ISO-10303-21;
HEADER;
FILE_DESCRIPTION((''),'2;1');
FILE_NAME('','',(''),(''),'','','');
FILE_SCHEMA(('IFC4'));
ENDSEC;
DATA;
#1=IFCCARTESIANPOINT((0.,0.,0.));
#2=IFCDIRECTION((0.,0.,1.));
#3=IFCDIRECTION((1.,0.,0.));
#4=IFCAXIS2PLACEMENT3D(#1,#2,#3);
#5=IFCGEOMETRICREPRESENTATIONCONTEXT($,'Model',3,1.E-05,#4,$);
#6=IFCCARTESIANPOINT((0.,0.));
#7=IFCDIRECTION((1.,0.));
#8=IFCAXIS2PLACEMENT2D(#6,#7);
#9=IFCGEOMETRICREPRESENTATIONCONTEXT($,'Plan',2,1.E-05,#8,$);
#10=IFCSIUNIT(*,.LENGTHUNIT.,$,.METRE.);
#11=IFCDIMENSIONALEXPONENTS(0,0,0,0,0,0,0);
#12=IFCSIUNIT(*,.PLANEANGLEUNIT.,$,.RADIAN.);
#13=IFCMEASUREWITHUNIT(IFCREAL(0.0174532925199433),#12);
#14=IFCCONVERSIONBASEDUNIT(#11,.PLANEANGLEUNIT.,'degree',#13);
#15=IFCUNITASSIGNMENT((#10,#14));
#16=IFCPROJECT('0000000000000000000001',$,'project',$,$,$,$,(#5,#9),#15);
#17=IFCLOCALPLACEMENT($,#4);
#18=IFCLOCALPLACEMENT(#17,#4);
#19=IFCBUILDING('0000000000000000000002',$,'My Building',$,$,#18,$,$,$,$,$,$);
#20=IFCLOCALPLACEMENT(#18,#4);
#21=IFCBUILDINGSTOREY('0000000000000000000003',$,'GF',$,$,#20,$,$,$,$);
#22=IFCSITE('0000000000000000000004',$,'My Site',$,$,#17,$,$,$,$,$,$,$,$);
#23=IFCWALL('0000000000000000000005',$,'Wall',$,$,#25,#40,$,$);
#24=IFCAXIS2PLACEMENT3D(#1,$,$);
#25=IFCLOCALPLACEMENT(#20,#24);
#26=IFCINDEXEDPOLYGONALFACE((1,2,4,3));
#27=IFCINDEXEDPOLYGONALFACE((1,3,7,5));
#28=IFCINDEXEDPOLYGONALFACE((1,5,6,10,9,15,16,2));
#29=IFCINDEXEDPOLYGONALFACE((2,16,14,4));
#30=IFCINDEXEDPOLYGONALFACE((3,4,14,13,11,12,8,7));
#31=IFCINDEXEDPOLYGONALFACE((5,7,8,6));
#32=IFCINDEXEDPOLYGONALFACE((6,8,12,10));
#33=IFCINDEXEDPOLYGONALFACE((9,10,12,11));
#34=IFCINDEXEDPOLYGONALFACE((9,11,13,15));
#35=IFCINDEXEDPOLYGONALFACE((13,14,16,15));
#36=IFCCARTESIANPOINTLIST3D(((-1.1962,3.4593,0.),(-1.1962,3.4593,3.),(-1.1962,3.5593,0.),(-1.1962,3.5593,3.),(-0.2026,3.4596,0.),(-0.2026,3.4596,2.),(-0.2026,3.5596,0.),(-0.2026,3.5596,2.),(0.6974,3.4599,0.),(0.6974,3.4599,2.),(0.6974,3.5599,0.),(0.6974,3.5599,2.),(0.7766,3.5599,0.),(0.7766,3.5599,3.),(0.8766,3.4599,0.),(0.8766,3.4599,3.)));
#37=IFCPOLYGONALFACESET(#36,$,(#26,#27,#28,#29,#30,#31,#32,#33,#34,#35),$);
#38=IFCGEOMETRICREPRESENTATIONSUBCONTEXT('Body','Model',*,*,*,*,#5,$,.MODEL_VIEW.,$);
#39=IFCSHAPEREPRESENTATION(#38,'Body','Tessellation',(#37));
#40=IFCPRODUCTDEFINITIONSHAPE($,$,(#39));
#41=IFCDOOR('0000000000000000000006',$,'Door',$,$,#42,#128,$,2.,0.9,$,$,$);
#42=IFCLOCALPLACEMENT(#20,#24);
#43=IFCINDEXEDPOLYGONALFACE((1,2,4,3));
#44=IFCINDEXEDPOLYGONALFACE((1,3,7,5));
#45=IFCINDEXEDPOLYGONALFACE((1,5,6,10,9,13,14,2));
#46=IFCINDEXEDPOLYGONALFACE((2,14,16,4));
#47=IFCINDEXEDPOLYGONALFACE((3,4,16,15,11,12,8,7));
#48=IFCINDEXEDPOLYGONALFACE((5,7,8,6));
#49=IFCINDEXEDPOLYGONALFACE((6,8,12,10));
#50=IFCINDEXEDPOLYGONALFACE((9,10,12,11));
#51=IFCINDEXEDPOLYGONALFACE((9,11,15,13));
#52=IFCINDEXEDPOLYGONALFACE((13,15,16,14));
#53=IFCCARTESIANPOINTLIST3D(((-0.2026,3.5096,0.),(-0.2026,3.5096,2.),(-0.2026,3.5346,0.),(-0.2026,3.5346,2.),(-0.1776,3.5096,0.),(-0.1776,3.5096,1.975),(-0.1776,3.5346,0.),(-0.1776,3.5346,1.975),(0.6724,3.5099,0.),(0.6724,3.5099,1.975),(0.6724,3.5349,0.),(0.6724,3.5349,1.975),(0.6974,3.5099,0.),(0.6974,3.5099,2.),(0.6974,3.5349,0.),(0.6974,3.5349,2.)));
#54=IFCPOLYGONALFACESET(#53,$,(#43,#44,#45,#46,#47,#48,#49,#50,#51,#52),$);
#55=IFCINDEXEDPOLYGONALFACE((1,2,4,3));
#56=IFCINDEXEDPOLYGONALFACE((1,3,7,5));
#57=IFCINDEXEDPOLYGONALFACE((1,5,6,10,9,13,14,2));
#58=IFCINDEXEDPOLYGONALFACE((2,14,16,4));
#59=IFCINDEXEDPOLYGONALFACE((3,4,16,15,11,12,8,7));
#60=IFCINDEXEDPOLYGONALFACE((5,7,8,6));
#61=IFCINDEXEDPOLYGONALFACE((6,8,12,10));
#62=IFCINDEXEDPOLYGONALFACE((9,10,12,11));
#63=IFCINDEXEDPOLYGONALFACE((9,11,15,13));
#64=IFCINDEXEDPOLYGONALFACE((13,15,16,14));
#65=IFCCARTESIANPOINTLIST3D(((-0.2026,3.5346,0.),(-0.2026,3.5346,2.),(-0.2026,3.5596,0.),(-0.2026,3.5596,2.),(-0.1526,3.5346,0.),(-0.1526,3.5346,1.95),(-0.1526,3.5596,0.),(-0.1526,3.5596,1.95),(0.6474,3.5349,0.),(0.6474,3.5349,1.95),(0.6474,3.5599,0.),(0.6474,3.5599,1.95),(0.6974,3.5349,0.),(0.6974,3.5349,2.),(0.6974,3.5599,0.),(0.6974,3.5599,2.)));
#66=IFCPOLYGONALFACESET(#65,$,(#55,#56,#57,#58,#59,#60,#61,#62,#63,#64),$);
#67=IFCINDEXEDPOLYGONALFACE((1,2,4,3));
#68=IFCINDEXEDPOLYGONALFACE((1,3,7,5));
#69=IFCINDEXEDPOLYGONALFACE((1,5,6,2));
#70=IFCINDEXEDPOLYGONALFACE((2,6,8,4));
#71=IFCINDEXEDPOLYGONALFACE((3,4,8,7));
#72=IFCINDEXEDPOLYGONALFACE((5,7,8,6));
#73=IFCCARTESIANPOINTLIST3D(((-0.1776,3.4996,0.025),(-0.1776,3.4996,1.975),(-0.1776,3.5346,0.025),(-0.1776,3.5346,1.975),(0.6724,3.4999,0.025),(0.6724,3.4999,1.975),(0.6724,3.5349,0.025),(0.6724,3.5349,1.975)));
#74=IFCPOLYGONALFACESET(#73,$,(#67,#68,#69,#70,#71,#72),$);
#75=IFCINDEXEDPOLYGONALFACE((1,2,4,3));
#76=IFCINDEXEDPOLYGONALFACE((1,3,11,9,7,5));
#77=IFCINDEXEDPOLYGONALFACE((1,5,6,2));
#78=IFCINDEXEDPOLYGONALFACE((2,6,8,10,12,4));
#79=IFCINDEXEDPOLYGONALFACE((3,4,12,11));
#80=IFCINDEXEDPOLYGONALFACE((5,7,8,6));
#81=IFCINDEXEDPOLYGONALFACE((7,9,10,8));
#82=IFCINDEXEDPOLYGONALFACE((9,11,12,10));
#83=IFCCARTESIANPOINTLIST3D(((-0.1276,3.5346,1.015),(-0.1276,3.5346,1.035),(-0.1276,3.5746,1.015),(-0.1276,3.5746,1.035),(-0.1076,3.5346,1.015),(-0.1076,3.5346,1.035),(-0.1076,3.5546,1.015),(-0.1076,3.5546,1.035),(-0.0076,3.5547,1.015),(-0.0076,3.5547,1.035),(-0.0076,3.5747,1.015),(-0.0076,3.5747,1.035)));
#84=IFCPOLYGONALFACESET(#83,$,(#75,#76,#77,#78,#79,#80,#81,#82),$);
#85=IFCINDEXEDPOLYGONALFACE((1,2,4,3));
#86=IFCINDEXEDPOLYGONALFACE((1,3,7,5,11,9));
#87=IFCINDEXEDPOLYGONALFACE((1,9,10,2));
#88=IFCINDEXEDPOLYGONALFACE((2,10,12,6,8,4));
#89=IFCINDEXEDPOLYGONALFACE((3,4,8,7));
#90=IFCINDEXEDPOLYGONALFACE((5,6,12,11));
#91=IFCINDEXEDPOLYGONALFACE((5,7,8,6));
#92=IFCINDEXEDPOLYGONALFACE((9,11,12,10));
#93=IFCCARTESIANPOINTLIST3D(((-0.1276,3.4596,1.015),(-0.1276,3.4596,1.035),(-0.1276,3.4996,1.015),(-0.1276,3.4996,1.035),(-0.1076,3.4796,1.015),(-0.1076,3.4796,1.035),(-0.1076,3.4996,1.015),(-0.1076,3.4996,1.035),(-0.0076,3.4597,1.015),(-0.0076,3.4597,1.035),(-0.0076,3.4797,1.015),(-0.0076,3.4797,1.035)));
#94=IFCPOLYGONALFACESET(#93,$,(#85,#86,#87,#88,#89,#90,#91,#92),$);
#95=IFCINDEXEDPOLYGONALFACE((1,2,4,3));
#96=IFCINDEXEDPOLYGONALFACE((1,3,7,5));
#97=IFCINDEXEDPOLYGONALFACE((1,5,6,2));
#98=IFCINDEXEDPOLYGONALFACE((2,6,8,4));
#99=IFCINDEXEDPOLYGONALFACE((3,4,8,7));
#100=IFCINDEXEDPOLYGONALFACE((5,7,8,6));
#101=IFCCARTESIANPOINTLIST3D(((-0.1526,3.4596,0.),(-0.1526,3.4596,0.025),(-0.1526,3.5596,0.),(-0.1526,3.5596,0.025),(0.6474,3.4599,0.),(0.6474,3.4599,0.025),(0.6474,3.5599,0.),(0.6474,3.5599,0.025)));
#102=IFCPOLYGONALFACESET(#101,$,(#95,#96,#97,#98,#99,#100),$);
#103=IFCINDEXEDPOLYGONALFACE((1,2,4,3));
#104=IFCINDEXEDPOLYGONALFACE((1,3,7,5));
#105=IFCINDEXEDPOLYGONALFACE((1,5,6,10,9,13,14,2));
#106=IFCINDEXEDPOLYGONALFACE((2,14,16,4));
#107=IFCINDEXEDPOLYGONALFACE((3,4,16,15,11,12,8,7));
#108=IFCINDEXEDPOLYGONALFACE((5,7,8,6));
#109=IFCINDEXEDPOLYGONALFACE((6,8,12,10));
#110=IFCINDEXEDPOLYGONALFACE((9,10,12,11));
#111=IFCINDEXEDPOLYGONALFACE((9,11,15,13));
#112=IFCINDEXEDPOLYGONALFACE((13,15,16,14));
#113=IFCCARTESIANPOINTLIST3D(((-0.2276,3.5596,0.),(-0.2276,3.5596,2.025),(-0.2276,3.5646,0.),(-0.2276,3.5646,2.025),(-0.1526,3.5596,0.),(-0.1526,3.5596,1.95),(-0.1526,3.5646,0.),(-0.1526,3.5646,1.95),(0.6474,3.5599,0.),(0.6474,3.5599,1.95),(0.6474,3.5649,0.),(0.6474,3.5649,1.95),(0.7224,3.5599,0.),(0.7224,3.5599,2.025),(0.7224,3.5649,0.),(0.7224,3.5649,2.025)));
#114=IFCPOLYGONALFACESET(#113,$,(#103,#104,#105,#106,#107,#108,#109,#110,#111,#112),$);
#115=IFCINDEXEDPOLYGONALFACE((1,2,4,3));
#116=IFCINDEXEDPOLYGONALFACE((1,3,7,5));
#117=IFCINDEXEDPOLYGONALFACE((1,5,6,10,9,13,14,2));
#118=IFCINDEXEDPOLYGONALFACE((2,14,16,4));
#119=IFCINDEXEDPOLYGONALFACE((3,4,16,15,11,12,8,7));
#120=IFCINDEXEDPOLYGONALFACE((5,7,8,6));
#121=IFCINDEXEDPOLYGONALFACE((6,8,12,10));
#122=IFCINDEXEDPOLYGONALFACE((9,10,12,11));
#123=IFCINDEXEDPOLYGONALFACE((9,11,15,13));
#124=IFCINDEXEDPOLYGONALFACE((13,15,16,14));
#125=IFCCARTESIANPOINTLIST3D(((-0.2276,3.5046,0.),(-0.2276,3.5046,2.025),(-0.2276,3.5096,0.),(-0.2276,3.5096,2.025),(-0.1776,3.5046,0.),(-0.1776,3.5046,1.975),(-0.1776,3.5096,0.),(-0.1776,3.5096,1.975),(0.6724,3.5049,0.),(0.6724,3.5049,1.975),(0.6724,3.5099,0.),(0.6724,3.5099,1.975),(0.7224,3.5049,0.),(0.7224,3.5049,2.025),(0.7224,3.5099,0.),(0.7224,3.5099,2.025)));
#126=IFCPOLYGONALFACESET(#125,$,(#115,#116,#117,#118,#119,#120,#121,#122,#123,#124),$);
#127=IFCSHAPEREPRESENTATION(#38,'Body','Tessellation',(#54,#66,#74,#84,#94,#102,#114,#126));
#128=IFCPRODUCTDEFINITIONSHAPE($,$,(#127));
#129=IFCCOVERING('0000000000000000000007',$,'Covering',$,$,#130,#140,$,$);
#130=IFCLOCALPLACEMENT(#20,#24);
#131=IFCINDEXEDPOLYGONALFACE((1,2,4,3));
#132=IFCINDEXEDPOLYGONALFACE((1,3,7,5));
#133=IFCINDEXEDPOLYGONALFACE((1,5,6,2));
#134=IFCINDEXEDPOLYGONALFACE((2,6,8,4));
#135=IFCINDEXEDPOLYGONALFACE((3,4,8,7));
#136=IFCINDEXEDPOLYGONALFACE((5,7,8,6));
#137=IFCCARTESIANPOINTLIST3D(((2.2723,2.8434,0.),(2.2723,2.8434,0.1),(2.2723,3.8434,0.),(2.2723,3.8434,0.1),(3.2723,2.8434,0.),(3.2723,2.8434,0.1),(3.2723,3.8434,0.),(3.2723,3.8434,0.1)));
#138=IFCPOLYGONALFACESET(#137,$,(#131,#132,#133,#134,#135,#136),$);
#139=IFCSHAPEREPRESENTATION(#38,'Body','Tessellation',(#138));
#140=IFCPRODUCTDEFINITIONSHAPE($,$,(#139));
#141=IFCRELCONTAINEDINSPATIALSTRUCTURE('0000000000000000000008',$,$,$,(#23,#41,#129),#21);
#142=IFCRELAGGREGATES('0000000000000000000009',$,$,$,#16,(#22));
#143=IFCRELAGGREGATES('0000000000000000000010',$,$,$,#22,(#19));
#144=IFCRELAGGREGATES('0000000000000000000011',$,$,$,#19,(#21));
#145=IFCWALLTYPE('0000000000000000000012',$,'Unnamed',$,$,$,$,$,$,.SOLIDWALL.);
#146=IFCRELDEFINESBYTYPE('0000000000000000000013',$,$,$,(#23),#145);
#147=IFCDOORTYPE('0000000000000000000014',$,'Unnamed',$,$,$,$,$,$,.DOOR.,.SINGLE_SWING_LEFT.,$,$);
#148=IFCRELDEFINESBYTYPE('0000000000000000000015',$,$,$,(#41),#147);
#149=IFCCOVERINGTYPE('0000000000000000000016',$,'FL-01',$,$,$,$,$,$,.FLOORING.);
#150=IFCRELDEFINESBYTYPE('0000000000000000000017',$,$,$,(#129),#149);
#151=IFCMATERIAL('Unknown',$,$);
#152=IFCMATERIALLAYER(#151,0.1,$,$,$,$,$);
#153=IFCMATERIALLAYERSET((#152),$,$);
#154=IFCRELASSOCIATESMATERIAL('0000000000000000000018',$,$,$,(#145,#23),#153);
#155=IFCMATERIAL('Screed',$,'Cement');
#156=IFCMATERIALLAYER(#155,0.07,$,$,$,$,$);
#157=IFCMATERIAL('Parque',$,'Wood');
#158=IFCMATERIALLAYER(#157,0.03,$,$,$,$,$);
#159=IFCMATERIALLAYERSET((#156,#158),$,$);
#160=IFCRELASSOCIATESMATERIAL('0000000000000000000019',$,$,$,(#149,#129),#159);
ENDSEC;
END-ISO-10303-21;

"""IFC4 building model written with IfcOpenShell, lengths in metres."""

from ifc_helpers import new_model, entity, si_unit, converted_unit, frame, origin_with_axes, origin_2d_with_axis, place, context, subcontext, project, spatial, line, indexed_curve, outline, extrude, shape, source, transform, mapped, material, layer, layer_set, layer_usage, type_object, type_shapes, element, fill, save


model = new_model("IFC4")

# Units and contexts
model_context = context("Model", 3, precision=1e-05, world=origin_with_axes())
plan_context = context("Plan", 2, precision=1e-05, world=origin_2d_with_axis())
body_context_1 = subcontext(model_context, "Body", "Model", "MODEL_VIEW")
body_context_2 = subcontext(plan_context, "Body", "Plan", "PLAN_VIEW")
ifc_project = project(units=[si_unit("LENGTHUNIT", "METRE"), converted_unit("PLANEANGLEUNIT", "degree", entity("IfcReal", 0.0174532925199433), si_unit("PLANEANGLEUNIT", "RADIAN"), dimensions=[0, 0, 0, 0, 0, 0, 0])], contexts=[model_context, plan_context])

# Site, building, storey
site_placement = place(None, origin_with_axes())
site = spatial("IfcSite", under=ifc_project, at=site_placement, Name="My Site")
building_placement = place(site_placement, origin_with_axes())
building = spatial("IfcBuilding", under=site, at=building_placement, Name="My Building")
storey_placement = place(building_placement, origin_with_axes())
storey = spatial("IfcBuildingStorey", under=building, at=storey_placement, Name="GF")

# Shared definitions
ifc_material_1 = material(Name="Unknown")

# Shared definitions
ifc_layer_1 = layer(ifc_material_1, 0.1)
ifc_layer_set_1 = layer_set([ifc_layer_1])
wall_type = type_object("IfcWallType", Name="Unnamed", PredefinedType="SOLIDWALL", material=ifc_layer_set_1)
shared_shape_1 = source(origin_with_axes(), body_context_1, "Body", "SweptSolid", [
    extrude(outline(indexed_curve([(0.0, 0.0), (0.9, 0.0), (0.9, 2.0), (0.0, 2.0)], segments=[line(1, 2, 3, 4, 1)])), frame((0.0, -0.6, 0.0), z_axis=(0.0, -1.0, 0.0), x_axis=(1.0, 0.0, 0.0)), (0.0, 0.0, -1.0), 1.2),
])
door_type_1 = type_object("IfcDoorType", Name="Unnamed", OperationType="SINGLE_SWING_LEFT", PredefinedType="DOOR")
shared_shape_2 = source(origin_with_axes(), body_context_1, "Body", "SweptSolid", [
    extrude(outline(indexed_curve([(0.0, 0.0), (0.0, 2.0), (0.9, 2.0), (0.9, 0.0), (0.875, 0.0), (0.875, 1.975), (0.025, 1.975), (0.025, 0.0)], segments=[line(1, 2, 3, 4, 5, 6, 7, 8, 1)])), frame((0.0, 0.025, 0.0), z_axis=(0.0, -1.0, 0.0), x_axis=(1.0, 0.0, 0.0)), (0.0, 0.0, -1.0), 0.025),
    extrude(outline(indexed_curve([(0.0, 0.0), (0.0, 2.0), (0.9, 2.0), (0.9, 0.0), (0.85, 0.0), (0.85, 1.95), (0.05, 1.95), (0.05, 0.0)], segments=[line(1, 2, 3, 4, 5, 6, 7, 8, 1)])), frame((0.0, 0.0, 0.0), z_axis=(0.0, -1.0, 0.0), x_axis=(1.0, 0.0, 0.0)), (0.0, 0.0, -1.0), 0.025),
    extrude(outline(indexed_curve([(0.0, 0.0), (0.85, 0.0), (0.85, 0.035), (0.0, 0.035)], segments=[line(1, 2, 3, 4, 1)])), frame((0.025, 0.025, 0.025), z_axis=(0.0, 0.0, 1.0), x_axis=(1.0, 0.0, 0.0)), (0.0, 0.0, 1.0), 1.95),
    extrude(outline(indexed_curve([(0.0, 0.0), (0.0, -0.04), (-0.12, -0.04), (-0.12, -0.02), (-0.02, -0.02), (-0.02, 0.0)], segments=[line(1, 2, 3, 4, 5, 6, 1)])), frame((0.825, 0.025, 1.015), z_axis=(0.0, 0.0, 1.0), x_axis=(1.0, 0.0, 0.0)), (0.0, 0.0, 1.0), 0.02),
    extrude(outline(indexed_curve([(0.0, 0.0), (0.0, 0.04), (-0.12, 0.04), (-0.12, 0.02), (-0.02, 0.02), (-0.02, 0.0)], segments=[line(1, 2, 3, 4, 5, 6, 1)])), frame((0.825, 0.06, 1.015), z_axis=(0.0, 0.0, 1.0), x_axis=(1.0, 0.0, 0.0)), (0.0, 0.0, 1.0), 0.02),
    extrude(outline(indexed_curve([(0.0, 0.0), (0.8, 0.0), (0.8, 0.1), (0.0, 0.1)], segments=[line(1, 2, 3, 4, 1)])), frame((0.05, 0.0, 0.0), z_axis=(0.0, 0.0, 1.0), x_axis=(1.0, 0.0, 0.0)), (0.0, 0.0, 1.0), 0.025),
    extrude(outline(indexed_curve([(0.0, 0.0), (0.0, 2.025), (0.95, 2.025), (0.95, 0.0), (0.875, 0.0), (0.875, 1.95), (0.075, 1.95), (0.075, 0.0)], segments=[line(1, 2, 3, 4, 5, 6, 7, 8, 1)])), frame((-0.025, -0.005, 0.0), z_axis=(0.0, -1.0, 0.0), x_axis=(1.0, 0.0, 0.0)), (0.0, 0.0, -1.0), 0.005),
    extrude(outline(indexed_curve([(0.0, 0.0), (0.0, 2.025), (0.95, 2.025), (0.95, 0.0), (0.9, 0.0), (0.9, 1.975), (0.05, 1.975), (0.05, 0.0)], segments=[line(1, 2, 3, 4, 5, 6, 7, 8, 1)])), frame((-0.025, 0.05, 0.0), z_axis=(0.0, -1.0, 0.0), x_axis=(1.0, 0.0, 0.0)), (0.0, 0.0, -1.0), 0.005),
])
shared_shape_3 = source(origin_with_axes(), body_context_2, "Body", "Curve2D", [
    entity("IfcIndexedPolyCurve", entity("IfcCartesianPointList2D", [[0.0, 0.0], [0.0, 0.05], [0.025, 0.05], [0.025, 0.025], [0.05, 0.025], [0.05, 0.0]]), [entity("IfcLineIndex", [1, 2, 3, 4, 5, 6, 1])]),
    entity("IfcIndexedPolyCurve", entity("IfcCartesianPointList2D", [[0.9, 0.0], [0.9, 0.05], [0.875, 0.05], [0.875, 0.025], [0.85, 0.025], [0.85, 0.0]]), [entity("IfcLineIndex", [1, 2, 3, 4, 5, 6, 1])]),
    entity("IfcTrimmedCurve", entity("IfcEllipse", entity("IfcAxis2Placement2D", entity("IfcCartesianPoint", [0.06, 0.05]), entity("IfcDirection", [1.0, 0.0])), 0.815, 0.85), [entity("IfcCartesianPoint", [0.875, 0.05])], [entity("IfcCartesianPoint", [0.06, 0.9])], True, "CARTESIAN"),
    entity("IfcIndexedPolyCurve", entity("IfcCartesianPointList2D", [[0.025, 0.05], [0.06, 0.05], [0.06, 0.9], [0.025, 0.9]]), [entity("IfcLineIndex", [1, 2, 3, 4, 1])]),
])
type_shapes(door_type_1, [shared_shape_2, shared_shape_3])

# Wall, opening, door
ifc_layer_usage_1 = layer_usage(ifc_layer_set_1, "AXIS2", "POSITIVE", 0.0)
wall_1_placement = place(storey_placement, frame((0.7766, 3.5599, 0.0), z_axis=(0.0, 0.0, 1.0), x_axis=(-1.0, -0.000309, 0.0)))
wall_1 = element("IfcWall", 1, at=wall_1_placement, inside=storey, type_object=wall_type, material=ifc_layer_usage_1, Name="Wall", context=body_context_1, shape_type="SweptSolid", body=[
    extrude(outline(indexed_curve([(0.0, 0.0), (-0.1, 0.1), (1.9728, 0.1), (1.9728, 0.0)], segments=[line(1, 2, 3, 4, 1)])), origin_with_axes(), (0.0, 0.0, 1.0), 3.0),
])
opening_1_placement = place(wall_1_placement, frame((0.0792, 0.0, 0.0), z_axis=(0.0, 0.0, 1.0), x_axis=(1.0, 0.0, 0.0)))
opening_1 = element("IfcOpeningElement", 2, at=opening_1_placement, cuts=wall_1, PredefinedType="OPENING", context=body_context_1, shape_type="MappedRepresentation", body=[
    mapped(shared_shape_1, transform((0.0, 0.0, 0.0), x_axis=(1.0, 0.0, 0.0), y_axis=(0.0, 1.0, 0.0), z_axis=(0.0, 0.0, 1.0), scale=1.0)),
])
door_1_placement = place(opening_1_placement, frame((0.0, 0.0, 0.0), z_axis=(0.0, 0.0, 1.0), x_axis=(1.0, 0.0, 0.0)))
door_1 = element("IfcDoor", 3, at=door_1_placement, inside=storey, type_object=door_type_1, Name="Door", OverallHeight=2.0, OverallWidth=0.9, shapes=[
    shape(body_context_1, "Body", "MappedRepresentation", [mapped(shared_shape_2, transform((0.0, 0.0, 0.0), x_axis=(1.0, 0.0, 0.0), y_axis=(0.0, 1.0, 0.0), z_axis=(0.0, 0.0, 1.0), scale=1.0))]),
    shape(body_context_2, "Body", "MappedRepresentation", [mapped(shared_shape_3, transform((0.0, 0.0, 0.0), x_axis=(1.0, 0.0, 0.0), y_axis=(0.0, 1.0, 0.0), z_axis=(0.0, 0.0, 1.0), scale=1.0))]),
])
fill(opening_1, door_1)

# Covering
ifc_material_2 = material(Name="Screed", Category="Cement")
ifc_layer_2 = layer(ifc_material_2, 0.07)
ifc_material_3 = material(Name="Parque", Category="Wood")
ifc_layer_3 = layer(ifc_material_3, 0.03)
ifc_layer_set_2 = layer_set([ifc_layer_2, ifc_layer_3])
ifc_layer_usage_2 = layer_usage(ifc_layer_set_2, "AXIS3", "POSITIVE", 0.0)
covering_type = type_object("IfcCoveringType", Name="FL-01", PredefinedType="FLOORING", material=ifc_layer_set_2)
covering_placement = place(storey_placement, frame((2.2723, 2.8434, 0.0), z_axis=(0.0, 0.0, 1.0), x_axis=(1.0, 0.0, 0.0)))
element("IfcCovering", 4, at=covering_placement, inside=storey, type_object=covering_type, material=ifc_layer_usage_2, Name="Covering", context=body_context_1, shape_type="SweptSolid", body=[
    extrude(outline(indexed_curve([(0.0, 0.0), (1.0, 0.0), (1.0, 1.0), (0.0, 1.0), (0.0, 0.0)])), None, (0.0, 0.0, 1.0), 0.1),
])

save(model, "model.ifc")
